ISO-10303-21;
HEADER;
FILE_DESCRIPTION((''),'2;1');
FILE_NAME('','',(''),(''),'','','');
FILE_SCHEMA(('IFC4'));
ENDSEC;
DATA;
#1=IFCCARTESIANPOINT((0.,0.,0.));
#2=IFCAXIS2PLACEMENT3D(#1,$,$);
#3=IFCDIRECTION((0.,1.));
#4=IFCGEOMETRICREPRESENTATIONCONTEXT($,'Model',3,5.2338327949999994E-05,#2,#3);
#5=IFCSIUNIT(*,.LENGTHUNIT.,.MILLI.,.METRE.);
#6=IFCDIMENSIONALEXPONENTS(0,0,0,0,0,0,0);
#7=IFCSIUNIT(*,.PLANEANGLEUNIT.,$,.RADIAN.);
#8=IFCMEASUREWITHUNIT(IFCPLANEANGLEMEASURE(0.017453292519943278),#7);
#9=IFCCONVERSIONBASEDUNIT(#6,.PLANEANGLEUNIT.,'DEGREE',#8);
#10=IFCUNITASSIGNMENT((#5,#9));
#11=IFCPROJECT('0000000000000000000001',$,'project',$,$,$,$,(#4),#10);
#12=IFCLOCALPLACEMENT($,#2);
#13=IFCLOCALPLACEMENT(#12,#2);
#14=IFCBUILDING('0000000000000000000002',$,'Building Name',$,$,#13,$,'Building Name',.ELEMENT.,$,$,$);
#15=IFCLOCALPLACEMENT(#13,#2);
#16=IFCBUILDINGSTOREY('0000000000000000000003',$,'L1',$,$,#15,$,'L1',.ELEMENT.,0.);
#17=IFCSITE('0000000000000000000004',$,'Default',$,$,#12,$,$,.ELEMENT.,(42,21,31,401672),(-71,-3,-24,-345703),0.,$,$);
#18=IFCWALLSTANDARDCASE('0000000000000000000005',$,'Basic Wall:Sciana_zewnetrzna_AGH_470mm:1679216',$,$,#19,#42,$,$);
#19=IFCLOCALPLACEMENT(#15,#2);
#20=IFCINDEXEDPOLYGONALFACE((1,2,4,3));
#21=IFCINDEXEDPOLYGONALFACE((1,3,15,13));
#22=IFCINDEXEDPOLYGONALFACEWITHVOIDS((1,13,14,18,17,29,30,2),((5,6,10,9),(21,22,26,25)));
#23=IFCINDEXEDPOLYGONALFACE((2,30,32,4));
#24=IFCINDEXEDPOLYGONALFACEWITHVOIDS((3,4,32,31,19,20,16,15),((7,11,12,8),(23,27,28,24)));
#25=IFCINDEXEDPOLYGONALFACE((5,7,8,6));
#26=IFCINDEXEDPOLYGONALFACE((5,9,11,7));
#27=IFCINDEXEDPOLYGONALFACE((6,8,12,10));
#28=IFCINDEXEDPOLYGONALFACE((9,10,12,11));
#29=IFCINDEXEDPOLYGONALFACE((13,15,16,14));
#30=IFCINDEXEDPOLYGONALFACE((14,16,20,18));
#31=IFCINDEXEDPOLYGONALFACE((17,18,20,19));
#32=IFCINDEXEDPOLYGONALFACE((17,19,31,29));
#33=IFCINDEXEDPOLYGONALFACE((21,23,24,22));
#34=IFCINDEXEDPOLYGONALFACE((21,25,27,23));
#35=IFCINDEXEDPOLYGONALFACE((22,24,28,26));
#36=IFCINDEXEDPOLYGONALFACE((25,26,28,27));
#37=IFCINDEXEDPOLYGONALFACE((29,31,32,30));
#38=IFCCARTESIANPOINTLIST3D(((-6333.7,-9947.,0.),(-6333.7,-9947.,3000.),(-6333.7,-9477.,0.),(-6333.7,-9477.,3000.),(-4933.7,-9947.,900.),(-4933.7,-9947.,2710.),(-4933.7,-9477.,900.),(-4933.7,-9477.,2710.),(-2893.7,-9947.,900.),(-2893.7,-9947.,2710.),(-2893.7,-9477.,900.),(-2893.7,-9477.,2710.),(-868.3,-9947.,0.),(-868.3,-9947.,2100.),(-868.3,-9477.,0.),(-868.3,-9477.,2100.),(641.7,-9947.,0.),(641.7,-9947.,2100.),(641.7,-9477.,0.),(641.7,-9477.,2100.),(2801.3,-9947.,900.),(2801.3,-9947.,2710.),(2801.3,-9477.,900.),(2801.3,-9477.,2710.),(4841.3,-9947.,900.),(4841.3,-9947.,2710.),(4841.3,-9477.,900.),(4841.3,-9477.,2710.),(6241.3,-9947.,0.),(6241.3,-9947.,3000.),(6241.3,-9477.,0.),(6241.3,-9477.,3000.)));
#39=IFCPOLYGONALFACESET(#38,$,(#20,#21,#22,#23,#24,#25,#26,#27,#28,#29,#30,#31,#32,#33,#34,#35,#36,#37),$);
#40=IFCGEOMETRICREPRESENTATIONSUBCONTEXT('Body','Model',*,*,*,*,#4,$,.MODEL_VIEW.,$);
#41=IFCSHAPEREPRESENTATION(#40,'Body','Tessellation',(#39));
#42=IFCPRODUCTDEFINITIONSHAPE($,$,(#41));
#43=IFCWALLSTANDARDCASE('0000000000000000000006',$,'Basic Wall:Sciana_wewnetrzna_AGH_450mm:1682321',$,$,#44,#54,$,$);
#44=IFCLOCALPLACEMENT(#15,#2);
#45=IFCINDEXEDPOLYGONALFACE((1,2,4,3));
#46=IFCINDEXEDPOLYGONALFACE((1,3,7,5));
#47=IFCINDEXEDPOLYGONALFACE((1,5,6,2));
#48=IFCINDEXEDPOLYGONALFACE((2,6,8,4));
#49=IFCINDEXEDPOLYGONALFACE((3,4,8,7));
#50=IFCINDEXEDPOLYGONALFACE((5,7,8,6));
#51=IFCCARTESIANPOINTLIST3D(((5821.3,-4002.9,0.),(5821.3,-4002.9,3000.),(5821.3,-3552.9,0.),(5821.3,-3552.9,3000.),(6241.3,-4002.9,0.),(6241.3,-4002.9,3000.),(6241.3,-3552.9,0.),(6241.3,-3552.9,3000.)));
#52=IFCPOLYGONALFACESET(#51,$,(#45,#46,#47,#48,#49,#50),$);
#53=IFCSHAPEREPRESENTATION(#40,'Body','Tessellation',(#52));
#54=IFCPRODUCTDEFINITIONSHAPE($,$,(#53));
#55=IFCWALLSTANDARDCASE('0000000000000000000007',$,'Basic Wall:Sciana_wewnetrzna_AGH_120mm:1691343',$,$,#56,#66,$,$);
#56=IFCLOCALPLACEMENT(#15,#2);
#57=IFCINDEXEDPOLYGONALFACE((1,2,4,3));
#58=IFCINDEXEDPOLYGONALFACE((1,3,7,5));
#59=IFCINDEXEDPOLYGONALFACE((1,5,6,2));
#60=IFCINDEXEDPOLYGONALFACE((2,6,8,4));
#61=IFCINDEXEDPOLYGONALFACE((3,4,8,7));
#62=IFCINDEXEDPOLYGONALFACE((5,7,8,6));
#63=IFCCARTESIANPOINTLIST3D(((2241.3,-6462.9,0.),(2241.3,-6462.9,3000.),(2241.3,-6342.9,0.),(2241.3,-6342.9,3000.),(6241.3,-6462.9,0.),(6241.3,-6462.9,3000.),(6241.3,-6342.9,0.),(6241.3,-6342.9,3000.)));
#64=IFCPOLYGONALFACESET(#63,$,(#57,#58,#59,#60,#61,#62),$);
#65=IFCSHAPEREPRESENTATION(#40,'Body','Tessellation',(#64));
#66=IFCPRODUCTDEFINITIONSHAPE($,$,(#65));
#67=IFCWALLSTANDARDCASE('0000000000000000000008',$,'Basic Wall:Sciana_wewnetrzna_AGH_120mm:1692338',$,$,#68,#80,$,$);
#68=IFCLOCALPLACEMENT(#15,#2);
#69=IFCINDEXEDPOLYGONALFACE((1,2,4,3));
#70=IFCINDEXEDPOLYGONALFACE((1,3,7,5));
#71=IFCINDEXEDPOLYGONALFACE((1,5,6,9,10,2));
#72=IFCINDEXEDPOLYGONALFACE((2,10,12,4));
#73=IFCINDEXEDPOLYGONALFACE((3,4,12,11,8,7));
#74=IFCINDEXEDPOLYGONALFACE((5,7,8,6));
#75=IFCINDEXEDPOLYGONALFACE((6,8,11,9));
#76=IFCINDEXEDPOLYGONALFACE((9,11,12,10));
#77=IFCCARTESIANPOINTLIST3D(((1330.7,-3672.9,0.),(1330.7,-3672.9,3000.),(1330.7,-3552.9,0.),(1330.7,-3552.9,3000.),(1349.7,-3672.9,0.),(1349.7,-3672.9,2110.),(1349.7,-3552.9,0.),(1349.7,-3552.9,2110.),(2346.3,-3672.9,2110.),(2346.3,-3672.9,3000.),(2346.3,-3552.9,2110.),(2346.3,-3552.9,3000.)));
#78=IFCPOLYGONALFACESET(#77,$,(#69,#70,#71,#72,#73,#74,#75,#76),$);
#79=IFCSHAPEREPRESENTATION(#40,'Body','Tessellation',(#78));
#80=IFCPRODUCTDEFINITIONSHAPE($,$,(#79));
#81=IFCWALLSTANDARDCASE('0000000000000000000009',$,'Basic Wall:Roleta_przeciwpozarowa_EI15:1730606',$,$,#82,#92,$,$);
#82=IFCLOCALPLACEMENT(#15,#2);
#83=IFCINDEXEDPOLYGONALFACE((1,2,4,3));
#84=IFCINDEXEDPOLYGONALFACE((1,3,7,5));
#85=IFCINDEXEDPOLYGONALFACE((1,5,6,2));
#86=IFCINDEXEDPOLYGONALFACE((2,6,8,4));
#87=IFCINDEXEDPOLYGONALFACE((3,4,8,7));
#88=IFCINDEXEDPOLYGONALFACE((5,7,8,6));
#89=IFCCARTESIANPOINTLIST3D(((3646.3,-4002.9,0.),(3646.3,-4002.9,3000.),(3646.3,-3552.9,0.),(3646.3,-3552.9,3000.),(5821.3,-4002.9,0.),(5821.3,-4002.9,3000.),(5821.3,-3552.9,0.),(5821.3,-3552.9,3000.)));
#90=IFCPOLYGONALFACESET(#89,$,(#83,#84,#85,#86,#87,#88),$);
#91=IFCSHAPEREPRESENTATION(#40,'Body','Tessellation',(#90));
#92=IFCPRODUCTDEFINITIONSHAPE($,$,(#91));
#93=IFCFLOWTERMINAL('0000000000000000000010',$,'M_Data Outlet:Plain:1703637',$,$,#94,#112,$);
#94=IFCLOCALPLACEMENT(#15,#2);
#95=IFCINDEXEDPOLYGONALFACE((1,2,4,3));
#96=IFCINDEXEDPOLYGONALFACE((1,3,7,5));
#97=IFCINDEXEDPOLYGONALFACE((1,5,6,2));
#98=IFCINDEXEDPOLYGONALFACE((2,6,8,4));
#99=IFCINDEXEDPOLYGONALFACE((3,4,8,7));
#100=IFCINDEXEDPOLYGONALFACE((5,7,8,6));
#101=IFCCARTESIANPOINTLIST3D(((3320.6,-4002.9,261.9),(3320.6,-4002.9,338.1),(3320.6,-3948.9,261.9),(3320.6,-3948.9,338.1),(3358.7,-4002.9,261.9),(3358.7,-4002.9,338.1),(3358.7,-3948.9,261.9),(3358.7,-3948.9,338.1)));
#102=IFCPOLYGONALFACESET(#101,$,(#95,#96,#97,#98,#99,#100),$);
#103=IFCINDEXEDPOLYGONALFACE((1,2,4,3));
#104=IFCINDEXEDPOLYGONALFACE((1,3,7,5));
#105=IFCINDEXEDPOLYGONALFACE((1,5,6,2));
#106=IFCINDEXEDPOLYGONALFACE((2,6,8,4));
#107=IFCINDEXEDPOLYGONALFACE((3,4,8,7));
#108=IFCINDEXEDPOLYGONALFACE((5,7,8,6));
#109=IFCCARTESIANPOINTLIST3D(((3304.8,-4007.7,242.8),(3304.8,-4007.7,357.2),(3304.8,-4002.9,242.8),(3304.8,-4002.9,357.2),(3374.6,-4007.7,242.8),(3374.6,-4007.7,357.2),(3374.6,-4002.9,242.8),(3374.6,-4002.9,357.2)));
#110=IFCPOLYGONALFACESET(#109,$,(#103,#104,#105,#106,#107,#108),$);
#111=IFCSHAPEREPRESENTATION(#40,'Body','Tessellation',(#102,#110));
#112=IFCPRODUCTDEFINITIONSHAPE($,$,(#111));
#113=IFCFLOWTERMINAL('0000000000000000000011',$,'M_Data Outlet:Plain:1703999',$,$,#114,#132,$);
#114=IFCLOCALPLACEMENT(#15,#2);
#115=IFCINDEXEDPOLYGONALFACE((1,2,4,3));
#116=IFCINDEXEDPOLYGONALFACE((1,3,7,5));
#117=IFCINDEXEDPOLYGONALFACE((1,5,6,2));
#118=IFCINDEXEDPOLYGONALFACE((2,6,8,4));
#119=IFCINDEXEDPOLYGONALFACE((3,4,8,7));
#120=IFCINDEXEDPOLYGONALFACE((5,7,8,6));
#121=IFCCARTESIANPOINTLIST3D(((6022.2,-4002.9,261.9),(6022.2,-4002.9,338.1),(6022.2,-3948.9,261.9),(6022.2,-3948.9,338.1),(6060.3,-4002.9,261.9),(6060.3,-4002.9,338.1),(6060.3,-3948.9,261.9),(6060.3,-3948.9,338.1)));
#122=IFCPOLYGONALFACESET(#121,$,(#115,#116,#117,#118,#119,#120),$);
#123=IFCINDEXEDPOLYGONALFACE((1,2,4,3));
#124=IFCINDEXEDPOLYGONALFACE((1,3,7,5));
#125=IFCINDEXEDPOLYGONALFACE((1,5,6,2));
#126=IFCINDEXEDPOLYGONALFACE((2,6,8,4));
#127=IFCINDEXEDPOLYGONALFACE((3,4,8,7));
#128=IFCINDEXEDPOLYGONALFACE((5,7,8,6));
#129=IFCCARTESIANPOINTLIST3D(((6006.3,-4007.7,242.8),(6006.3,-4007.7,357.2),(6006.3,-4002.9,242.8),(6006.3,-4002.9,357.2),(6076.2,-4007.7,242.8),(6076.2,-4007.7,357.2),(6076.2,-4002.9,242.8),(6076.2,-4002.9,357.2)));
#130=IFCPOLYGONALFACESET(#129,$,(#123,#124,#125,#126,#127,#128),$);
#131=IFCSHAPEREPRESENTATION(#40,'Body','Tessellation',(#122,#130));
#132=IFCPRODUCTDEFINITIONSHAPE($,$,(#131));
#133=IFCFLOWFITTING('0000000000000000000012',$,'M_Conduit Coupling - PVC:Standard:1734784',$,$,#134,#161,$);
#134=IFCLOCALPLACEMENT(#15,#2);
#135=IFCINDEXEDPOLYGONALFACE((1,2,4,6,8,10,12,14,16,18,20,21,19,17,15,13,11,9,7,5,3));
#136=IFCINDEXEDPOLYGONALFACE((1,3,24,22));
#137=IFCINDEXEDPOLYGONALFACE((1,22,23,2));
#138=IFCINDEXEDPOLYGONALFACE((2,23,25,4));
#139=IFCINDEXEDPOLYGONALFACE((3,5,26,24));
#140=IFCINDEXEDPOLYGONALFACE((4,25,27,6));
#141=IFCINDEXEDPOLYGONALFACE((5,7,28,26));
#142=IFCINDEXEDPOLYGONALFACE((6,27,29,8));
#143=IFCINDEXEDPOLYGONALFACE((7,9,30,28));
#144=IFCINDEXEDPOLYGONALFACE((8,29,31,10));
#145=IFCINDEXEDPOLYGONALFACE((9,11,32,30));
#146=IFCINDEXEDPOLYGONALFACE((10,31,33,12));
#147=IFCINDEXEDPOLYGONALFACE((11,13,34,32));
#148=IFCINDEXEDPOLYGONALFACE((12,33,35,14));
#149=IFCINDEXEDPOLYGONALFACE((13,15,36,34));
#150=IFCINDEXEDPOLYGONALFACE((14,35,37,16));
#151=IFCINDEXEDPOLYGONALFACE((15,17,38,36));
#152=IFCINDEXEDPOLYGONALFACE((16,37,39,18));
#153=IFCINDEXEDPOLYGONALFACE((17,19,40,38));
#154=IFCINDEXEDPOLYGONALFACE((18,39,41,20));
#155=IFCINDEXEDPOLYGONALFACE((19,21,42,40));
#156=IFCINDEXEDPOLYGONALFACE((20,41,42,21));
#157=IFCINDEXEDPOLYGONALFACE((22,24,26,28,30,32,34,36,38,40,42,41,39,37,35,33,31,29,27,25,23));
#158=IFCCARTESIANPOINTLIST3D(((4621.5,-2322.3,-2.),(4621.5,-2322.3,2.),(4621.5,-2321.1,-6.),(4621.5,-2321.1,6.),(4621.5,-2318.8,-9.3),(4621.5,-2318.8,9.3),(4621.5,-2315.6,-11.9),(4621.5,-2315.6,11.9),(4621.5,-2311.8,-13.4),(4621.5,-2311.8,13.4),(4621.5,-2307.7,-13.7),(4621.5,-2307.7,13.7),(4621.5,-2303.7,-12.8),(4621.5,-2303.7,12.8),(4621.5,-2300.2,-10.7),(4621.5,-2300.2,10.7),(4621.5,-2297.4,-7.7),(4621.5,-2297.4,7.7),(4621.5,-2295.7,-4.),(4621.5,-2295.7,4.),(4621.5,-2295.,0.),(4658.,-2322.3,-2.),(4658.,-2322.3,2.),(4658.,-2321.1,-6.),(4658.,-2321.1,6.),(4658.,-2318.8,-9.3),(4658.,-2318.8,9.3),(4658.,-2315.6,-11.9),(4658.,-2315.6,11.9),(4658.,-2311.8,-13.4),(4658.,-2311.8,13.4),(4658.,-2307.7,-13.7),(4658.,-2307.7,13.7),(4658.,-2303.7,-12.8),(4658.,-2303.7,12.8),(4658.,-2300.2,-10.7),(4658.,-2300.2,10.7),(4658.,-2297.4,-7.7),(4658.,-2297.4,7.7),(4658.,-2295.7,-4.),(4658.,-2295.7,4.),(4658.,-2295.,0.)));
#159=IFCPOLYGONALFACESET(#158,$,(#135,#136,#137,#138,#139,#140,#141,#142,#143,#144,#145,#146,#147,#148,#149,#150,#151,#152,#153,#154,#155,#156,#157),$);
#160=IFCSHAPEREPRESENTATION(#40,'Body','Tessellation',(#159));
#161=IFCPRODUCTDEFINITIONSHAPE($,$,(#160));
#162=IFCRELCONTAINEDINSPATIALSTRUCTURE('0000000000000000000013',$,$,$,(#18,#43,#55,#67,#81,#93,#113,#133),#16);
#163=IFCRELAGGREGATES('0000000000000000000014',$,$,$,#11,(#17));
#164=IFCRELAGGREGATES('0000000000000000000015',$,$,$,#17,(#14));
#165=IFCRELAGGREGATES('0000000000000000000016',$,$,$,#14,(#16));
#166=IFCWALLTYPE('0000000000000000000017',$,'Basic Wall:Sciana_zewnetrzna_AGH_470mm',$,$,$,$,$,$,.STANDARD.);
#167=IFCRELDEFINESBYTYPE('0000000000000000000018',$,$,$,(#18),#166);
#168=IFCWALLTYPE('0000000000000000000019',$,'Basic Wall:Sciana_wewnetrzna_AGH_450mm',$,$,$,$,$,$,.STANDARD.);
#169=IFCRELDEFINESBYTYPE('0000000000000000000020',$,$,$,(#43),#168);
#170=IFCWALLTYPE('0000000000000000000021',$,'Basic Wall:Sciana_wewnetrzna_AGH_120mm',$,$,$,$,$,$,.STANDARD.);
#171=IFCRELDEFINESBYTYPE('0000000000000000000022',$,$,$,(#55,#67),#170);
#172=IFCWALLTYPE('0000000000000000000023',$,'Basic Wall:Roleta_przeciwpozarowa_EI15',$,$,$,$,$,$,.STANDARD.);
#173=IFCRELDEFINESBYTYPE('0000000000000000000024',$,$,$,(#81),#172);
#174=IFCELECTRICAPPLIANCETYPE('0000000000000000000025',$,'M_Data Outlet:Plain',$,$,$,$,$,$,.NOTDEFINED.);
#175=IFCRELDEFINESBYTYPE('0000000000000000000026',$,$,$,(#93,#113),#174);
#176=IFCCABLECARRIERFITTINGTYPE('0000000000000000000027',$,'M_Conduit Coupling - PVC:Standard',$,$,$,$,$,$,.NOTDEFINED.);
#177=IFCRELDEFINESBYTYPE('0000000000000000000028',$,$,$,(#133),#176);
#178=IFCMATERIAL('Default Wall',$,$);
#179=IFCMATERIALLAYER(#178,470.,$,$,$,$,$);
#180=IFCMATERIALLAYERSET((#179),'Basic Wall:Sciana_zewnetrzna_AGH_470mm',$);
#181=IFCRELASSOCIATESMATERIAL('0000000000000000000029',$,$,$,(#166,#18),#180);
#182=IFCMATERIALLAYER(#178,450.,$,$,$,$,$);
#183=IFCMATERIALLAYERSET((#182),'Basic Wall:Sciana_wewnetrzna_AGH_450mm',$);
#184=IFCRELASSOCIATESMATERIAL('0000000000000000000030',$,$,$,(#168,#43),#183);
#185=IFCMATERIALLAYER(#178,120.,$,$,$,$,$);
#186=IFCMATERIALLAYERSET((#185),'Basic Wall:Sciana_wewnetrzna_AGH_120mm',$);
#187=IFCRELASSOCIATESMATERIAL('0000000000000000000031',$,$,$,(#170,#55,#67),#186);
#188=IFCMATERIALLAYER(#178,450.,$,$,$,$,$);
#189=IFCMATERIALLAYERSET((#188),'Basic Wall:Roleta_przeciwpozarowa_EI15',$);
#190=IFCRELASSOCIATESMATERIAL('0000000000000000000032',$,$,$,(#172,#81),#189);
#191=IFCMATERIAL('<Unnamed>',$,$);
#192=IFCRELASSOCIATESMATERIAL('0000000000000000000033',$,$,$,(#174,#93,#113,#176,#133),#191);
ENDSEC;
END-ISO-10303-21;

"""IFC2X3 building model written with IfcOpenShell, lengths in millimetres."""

from ifc_helpers import new_model, entity, si_unit, converted_unit, direction, frame, frame_2d, origin, place, context, subcontext, project, spatial, rectangle, circle, extrude, source, transform, mapped, material, layer, layer_set, layer_usage, type_object, type_shapes, element, save


model = new_model("IFC2X3")

# Units and contexts
model_context = context("Model", 3, precision=5.2338327949999994e-05, world=origin(), true_north=direction((0.0, 1.0)))
body_context = subcontext(model_context, "Body", "Model", "MODEL_VIEW")
ifc_project = project(units=[si_unit("LENGTHUNIT", "METRE", prefix="MILLI"), converted_unit("PLANEANGLEUNIT", "DEGREE", entity("IfcPlaneAngleMeasure", 0.017453292519943278), si_unit("PLANEANGLEUNIT", "RADIAN"), dimensions=[0, 0, 0, 0, 0, 0, 0])], contexts=[model_context])

# Site, building, storey
site_placement = place(None, origin())
site = spatial("IfcSite", under=ifc_project, at=site_placement, Name="Default", CompositionType="ELEMENT", RefLatitude=(42, 21, 31, 401672), RefLongitude=(-71, -3, -24, -345703), RefElevation=0.0)
building_placement = place(site_placement, origin())
building = spatial("IfcBuilding", under=site, at=building_placement, Name="Building Name", LongName="Building Name", CompositionType="ELEMENT")
storey_placement = place(building_placement, origin())
storey = spatial("IfcBuildingStorey", under=building, at=storey_placement, Name="L1", LongName="L1", CompositionType="ELEMENT", Elevation=0.0)

# Wall, openings
ifc_material_1 = material(Name="Default Wall")
ifc_layer_1 = layer(ifc_material_1, 470.0)
ifc_layer_set_1 = layer_set([ifc_layer_1], Name="Basic Wall:Sciana_zewnetrzna_AGH_470mm")
ifc_layer_usage_1 = layer_usage(ifc_layer_set_1, "AXIS2", "NEGATIVE", 235.0)
wall_type_1 = type_object("IfcWallType", Name="Basic Wall:Sciana_zewnetrzna_AGH_470mm", PredefinedType="STANDARD", material=ifc_layer_set_1)
wall_1_placement = place(storey_placement, frame((6241.3, -9712.0, 0.0), z_axis=(0.0, 0.0, 1.0), x_axis=(-1.0, 0.0, 0.0)))
wall_1 = element("IfcWallStandardCase", 1, at=wall_1_placement, inside=storey, type_object=wall_type_1, material=ifc_layer_usage_1, Name="Basic Wall:Sciana_zewnetrzna_AGH_470mm:1679216", context=body_context, shape_type="SweptSolid", body=[
    extrude(rectangle(XDim=12575.0, YDim=470.0, at=frame_2d((6287.5, 0.0), x_axis=(1.0, 0.0))), origin(), (0.0, 0.0, 1.0), 3000.0),
])
opening_1_placement = place(wall_1_placement, frame((7109.5, 235.0, 0.0)))
element("IfcOpeningElement", 2, at=opening_1_placement, cuts=wall_1, ObjectType="Opening", context=body_context, shape_type="SweptSolid", body=[
    extrude(rectangle(XDim=2100.0, YDim=1510.0, at=frame_2d((1050.0, 755.0), x_axis=(1.0, 0.0))), frame((0.0, 0.0, 0.0), z_axis=(0.0, -1.0, 0.0), x_axis=(0.0, 0.0, 1.0)), (0.0, 0.0, 1.0), 470.0),
])
opening_2_placement = place(wall_1_placement, frame((9135.0, -235.0, 900.0)))
element("IfcOpeningElement", 3, at=opening_2_placement, cuts=wall_1, ObjectType="Opening", context=body_context, shape_type="SweptSolid", body=[
    extrude(rectangle(XDim=1810.0, YDim=2040.0, at=frame_2d((905.0, 1020.0), x_axis=(-1.0, 0.0))), frame((0.0, 0.0, 0.0), z_axis=(0.0, 1.0, 0.0), x_axis=(0.0, 0.0, 1.0)), (0.0, 0.0, 1.0), 470.0),
])
opening_3_placement = place(wall_1_placement, frame((1400.0, -235.0, 900.0)))
element("IfcOpeningElement", 4, at=opening_3_placement, cuts=wall_1, ObjectType="Opening", context=body_context, shape_type="SweptSolid", body=[
    extrude(rectangle(XDim=1810.0, YDim=2040.0, at=frame_2d((905.0, 1020.0), x_axis=(-1.0, 0.0))), frame((0.0, 0.0, 0.0), z_axis=(0.0, 1.0, 0.0), x_axis=(0.0, 0.0, 1.0)), (0.0, 0.0, 1.0), 470.0),
])

# Shared definitions
ifc_layer_2 = layer(ifc_material_1, 450.0)
ifc_layer_set_2 = layer_set([ifc_layer_2], Name="Basic Wall:Sciana_wewnetrzna_AGH_450mm")
wall_type_2 = type_object("IfcWallType", Name="Basic Wall:Sciana_wewnetrzna_AGH_450mm", PredefinedType="STANDARD", material=ifc_layer_set_2)

# Walls
ifc_layer_usage_2 = layer_usage(ifc_layer_set_2, "AXIS2", "NEGATIVE", 225.0)
wall_2_placement = place(storey_placement, frame((5821.3, -3777.9, 0.0)))
element("IfcWallStandardCase", 5, at=wall_2_placement, inside=storey, type_object=wall_type_2, material=ifc_layer_usage_2, Name="Basic Wall:Sciana_wewnetrzna_AGH_450mm:1682321", context=body_context, shape_type="SweptSolid", body=[
    extrude(rectangle(XDim=420.0, YDim=450.0, at=frame_2d((210.0, 0.0), x_axis=(-1.0, 0.0))), origin(), (0.0, 0.0, 1.0), 3000.0),
])
ifc_layer_3 = layer(ifc_material_1, 120.0)
ifc_layer_set_3 = layer_set([ifc_layer_3], Name="Basic Wall:Sciana_wewnetrzna_AGH_120mm")
ifc_layer_usage_3 = layer_usage(ifc_layer_set_3, "AXIS2", "NEGATIVE", 60.0)
wall_type_3 = type_object("IfcWallType", Name="Basic Wall:Sciana_wewnetrzna_AGH_120mm", PredefinedType="STANDARD", material=ifc_layer_set_3)
wall_3_placement = place(storey_placement, frame((6241.3, -6402.9, 0.0), z_axis=(0.0, 0.0, 1.0), x_axis=(-1.0, 0.0, 0.0)))
element("IfcWallStandardCase", 6, at=wall_3_placement, inside=storey, type_object=wall_type_3, material=ifc_layer_usage_3, Name="Basic Wall:Sciana_wewnetrzna_AGH_120mm:1691343", context=body_context, shape_type="SweptSolid", body=[
    extrude(rectangle(XDim=4000.0, YDim=120.0, at=frame_2d((2000.0, 0.0), x_axis=(-1.0, 0.0))), origin(), (0.0, 0.0, 1.0), 3000.0),
])

# Wall, opening
ifc_layer_usage_4 = layer_usage(ifc_layer_set_3, "AXIS2", "NEGATIVE", 60.0)
wall_4_placement = place(storey_placement, frame((1330.7, -3612.9, 0.0)))
wall_4 = element("IfcWallStandardCase", 7, at=wall_4_placement, inside=storey, type_object=wall_type_3, material=ifc_layer_usage_4, Name="Basic Wall:Sciana_wewnetrzna_AGH_120mm:1692338", context=body_context, shape_type="SweptSolid", body=[
    extrude(rectangle(XDim=1015.6, YDim=120.0, at=frame_2d((507.8, 0.0), x_axis=(-1.0, 0.0))), origin(), (0.0, 0.0, 1.0), 3000.0),
])
opening_4_placement = place(wall_4_placement, frame((1019.1, 60.0, 0.0)))
element("IfcOpeningElement", 8, at=opening_4_placement, cuts=wall_4, ObjectType="Opening", context=body_context, shape_type="SweptSolid", body=[
    extrude(rectangle(XDim=2110.0, YDim=1000.0, at=frame_2d((1055.0, 500.0), x_axis=(1.0, 0.0))), frame((0.0, 0.0, 0.0), z_axis=(0.0, -1.0, 0.0), x_axis=(0.0, 0.0, 1.0)), (0.0, 0.0, 1.0), 120.0),
])

# Wall
ifc_layer_4 = layer(ifc_material_1, 450.0)
ifc_layer_set_4 = layer_set([ifc_layer_4], Name="Basic Wall:Roleta_przeciwpozarowa_EI15")
ifc_layer_usage_5 = layer_usage(ifc_layer_set_4, "AXIS2", "NEGATIVE", 225.0)
wall_type_4 = type_object("IfcWallType", Name="Basic Wall:Roleta_przeciwpozarowa_EI15", PredefinedType="STANDARD", material=ifc_layer_set_4)
wall_5_placement = place(storey_placement, frame((3646.3, -3777.9, 0.0)))
element("IfcWallStandardCase", 9, at=wall_5_placement, inside=storey, type_object=wall_type_4, material=ifc_layer_usage_5, Name="Basic Wall:Roleta_przeciwpozarowa_EI15:1730606", context=body_context, shape_type="SweptSolid", body=[
    extrude(rectangle(XDim=2175.0, YDim=450.0, at=frame_2d((1087.5, 0.0), x_axis=(-1.0, 0.0))), origin(), (0.0, 0.0, 1.0), 3000.0),
])

# Flow terminals
ifc_material_2 = material(Name="<Unnamed>")
electric_appliance_type = type_object("IfcElectricApplianceType", Name="M_Data Outlet:Plain", PredefinedType="NOTDEFINED", material=ifc_material_2)
shared_shape_1 = source(origin(), body_context, "Body", "SweptSolid", [
    extrude(rectangle(XDim=38.1, YDim=76.2, at=frame_2d((0.0, 0.0), x_axis=(1.0, 0.0))), frame((0.0, 0.0, -54.0), z_axis=(0.0, 0.0, 1.0), x_axis=(-1.0, 0.0, 0.0)), (0.0, 0.0, 1.0), 54.0),
    extrude(rectangle(XDim=69.9, YDim=114.3, at=frame_2d((0.0, 0.0), x_axis=(1.0, 0.0))), frame((0.0, 0.0, 0.0), z_axis=(0.0, 0.0, 1.0), x_axis=(-1.0, 0.0, 0.0)), (0.0, 0.0, 1.0), 4.8),
])
type_shapes(electric_appliance_type, [shared_shape_1])
for number, where, z_axis, x_axis, name in (
    (10, (3339.7, -4002.9, 300.0), (0.0, -1.0, 0.0), (1.0, 0.0, 0.0), "M_Data Outlet:Plain:1703637"),
    (11, (6041.3, -4002.9, 300.0), (0.0, -1.0, 0.0), (1.0, 0.0, 0.0), "M_Data Outlet:Plain:1703999"),
):
    element("IfcFlowTerminal", number, at=place(storey_placement, frame(where, z_axis=z_axis, x_axis=x_axis)), inside=storey, type_object=electric_appliance_type, material=ifc_material_2, Name=name, context=body_context, shape_type="MappedRepresentation", body=[
        mapped(shared_shape_1, transform((0.0, 0.0, 0.0), scale=1.0)),
    ])

# Flow fitting
cable_carrier_fitting_type = type_object("IfcCableCarrierFittingType", Name="M_Conduit Coupling - PVC:Standard", PredefinedType="NOTDEFINED", material=ifc_material_2)
shared_shape_2 = source(origin(), body_context, "Body", "SweptSolid", [
    extrude(circle(Radius=13.7, at=frame_2d((0.0, 0.0), x_axis=(1.0, 0.0))), frame((0.0, 0.0, 0.0), z_axis=(1.0, 0.0, 0.0), x_axis=(0.0, 1.0, 0.0)), (0.0, 0.0, 1.0), 36.5),
])
type_shapes(cable_carrier_fitting_type, [shared_shape_2])
for number, where, name in (
    (12, (4621.5, -2308.8, 0.0), "M_Conduit Coupling - PVC:Standard:1734784"),
):
    element("IfcFlowFitting", number, at=place(storey_placement, frame(where)), inside=storey, type_object=cable_carrier_fitting_type, material=ifc_material_2, Name=name, context=body_context, shape_type="MappedRepresentation", body=[
        mapped(shared_shape_2, transform((0.0, 0.0, 0.0), scale=1.0)),
    ])

save(model, "model.ifc")
